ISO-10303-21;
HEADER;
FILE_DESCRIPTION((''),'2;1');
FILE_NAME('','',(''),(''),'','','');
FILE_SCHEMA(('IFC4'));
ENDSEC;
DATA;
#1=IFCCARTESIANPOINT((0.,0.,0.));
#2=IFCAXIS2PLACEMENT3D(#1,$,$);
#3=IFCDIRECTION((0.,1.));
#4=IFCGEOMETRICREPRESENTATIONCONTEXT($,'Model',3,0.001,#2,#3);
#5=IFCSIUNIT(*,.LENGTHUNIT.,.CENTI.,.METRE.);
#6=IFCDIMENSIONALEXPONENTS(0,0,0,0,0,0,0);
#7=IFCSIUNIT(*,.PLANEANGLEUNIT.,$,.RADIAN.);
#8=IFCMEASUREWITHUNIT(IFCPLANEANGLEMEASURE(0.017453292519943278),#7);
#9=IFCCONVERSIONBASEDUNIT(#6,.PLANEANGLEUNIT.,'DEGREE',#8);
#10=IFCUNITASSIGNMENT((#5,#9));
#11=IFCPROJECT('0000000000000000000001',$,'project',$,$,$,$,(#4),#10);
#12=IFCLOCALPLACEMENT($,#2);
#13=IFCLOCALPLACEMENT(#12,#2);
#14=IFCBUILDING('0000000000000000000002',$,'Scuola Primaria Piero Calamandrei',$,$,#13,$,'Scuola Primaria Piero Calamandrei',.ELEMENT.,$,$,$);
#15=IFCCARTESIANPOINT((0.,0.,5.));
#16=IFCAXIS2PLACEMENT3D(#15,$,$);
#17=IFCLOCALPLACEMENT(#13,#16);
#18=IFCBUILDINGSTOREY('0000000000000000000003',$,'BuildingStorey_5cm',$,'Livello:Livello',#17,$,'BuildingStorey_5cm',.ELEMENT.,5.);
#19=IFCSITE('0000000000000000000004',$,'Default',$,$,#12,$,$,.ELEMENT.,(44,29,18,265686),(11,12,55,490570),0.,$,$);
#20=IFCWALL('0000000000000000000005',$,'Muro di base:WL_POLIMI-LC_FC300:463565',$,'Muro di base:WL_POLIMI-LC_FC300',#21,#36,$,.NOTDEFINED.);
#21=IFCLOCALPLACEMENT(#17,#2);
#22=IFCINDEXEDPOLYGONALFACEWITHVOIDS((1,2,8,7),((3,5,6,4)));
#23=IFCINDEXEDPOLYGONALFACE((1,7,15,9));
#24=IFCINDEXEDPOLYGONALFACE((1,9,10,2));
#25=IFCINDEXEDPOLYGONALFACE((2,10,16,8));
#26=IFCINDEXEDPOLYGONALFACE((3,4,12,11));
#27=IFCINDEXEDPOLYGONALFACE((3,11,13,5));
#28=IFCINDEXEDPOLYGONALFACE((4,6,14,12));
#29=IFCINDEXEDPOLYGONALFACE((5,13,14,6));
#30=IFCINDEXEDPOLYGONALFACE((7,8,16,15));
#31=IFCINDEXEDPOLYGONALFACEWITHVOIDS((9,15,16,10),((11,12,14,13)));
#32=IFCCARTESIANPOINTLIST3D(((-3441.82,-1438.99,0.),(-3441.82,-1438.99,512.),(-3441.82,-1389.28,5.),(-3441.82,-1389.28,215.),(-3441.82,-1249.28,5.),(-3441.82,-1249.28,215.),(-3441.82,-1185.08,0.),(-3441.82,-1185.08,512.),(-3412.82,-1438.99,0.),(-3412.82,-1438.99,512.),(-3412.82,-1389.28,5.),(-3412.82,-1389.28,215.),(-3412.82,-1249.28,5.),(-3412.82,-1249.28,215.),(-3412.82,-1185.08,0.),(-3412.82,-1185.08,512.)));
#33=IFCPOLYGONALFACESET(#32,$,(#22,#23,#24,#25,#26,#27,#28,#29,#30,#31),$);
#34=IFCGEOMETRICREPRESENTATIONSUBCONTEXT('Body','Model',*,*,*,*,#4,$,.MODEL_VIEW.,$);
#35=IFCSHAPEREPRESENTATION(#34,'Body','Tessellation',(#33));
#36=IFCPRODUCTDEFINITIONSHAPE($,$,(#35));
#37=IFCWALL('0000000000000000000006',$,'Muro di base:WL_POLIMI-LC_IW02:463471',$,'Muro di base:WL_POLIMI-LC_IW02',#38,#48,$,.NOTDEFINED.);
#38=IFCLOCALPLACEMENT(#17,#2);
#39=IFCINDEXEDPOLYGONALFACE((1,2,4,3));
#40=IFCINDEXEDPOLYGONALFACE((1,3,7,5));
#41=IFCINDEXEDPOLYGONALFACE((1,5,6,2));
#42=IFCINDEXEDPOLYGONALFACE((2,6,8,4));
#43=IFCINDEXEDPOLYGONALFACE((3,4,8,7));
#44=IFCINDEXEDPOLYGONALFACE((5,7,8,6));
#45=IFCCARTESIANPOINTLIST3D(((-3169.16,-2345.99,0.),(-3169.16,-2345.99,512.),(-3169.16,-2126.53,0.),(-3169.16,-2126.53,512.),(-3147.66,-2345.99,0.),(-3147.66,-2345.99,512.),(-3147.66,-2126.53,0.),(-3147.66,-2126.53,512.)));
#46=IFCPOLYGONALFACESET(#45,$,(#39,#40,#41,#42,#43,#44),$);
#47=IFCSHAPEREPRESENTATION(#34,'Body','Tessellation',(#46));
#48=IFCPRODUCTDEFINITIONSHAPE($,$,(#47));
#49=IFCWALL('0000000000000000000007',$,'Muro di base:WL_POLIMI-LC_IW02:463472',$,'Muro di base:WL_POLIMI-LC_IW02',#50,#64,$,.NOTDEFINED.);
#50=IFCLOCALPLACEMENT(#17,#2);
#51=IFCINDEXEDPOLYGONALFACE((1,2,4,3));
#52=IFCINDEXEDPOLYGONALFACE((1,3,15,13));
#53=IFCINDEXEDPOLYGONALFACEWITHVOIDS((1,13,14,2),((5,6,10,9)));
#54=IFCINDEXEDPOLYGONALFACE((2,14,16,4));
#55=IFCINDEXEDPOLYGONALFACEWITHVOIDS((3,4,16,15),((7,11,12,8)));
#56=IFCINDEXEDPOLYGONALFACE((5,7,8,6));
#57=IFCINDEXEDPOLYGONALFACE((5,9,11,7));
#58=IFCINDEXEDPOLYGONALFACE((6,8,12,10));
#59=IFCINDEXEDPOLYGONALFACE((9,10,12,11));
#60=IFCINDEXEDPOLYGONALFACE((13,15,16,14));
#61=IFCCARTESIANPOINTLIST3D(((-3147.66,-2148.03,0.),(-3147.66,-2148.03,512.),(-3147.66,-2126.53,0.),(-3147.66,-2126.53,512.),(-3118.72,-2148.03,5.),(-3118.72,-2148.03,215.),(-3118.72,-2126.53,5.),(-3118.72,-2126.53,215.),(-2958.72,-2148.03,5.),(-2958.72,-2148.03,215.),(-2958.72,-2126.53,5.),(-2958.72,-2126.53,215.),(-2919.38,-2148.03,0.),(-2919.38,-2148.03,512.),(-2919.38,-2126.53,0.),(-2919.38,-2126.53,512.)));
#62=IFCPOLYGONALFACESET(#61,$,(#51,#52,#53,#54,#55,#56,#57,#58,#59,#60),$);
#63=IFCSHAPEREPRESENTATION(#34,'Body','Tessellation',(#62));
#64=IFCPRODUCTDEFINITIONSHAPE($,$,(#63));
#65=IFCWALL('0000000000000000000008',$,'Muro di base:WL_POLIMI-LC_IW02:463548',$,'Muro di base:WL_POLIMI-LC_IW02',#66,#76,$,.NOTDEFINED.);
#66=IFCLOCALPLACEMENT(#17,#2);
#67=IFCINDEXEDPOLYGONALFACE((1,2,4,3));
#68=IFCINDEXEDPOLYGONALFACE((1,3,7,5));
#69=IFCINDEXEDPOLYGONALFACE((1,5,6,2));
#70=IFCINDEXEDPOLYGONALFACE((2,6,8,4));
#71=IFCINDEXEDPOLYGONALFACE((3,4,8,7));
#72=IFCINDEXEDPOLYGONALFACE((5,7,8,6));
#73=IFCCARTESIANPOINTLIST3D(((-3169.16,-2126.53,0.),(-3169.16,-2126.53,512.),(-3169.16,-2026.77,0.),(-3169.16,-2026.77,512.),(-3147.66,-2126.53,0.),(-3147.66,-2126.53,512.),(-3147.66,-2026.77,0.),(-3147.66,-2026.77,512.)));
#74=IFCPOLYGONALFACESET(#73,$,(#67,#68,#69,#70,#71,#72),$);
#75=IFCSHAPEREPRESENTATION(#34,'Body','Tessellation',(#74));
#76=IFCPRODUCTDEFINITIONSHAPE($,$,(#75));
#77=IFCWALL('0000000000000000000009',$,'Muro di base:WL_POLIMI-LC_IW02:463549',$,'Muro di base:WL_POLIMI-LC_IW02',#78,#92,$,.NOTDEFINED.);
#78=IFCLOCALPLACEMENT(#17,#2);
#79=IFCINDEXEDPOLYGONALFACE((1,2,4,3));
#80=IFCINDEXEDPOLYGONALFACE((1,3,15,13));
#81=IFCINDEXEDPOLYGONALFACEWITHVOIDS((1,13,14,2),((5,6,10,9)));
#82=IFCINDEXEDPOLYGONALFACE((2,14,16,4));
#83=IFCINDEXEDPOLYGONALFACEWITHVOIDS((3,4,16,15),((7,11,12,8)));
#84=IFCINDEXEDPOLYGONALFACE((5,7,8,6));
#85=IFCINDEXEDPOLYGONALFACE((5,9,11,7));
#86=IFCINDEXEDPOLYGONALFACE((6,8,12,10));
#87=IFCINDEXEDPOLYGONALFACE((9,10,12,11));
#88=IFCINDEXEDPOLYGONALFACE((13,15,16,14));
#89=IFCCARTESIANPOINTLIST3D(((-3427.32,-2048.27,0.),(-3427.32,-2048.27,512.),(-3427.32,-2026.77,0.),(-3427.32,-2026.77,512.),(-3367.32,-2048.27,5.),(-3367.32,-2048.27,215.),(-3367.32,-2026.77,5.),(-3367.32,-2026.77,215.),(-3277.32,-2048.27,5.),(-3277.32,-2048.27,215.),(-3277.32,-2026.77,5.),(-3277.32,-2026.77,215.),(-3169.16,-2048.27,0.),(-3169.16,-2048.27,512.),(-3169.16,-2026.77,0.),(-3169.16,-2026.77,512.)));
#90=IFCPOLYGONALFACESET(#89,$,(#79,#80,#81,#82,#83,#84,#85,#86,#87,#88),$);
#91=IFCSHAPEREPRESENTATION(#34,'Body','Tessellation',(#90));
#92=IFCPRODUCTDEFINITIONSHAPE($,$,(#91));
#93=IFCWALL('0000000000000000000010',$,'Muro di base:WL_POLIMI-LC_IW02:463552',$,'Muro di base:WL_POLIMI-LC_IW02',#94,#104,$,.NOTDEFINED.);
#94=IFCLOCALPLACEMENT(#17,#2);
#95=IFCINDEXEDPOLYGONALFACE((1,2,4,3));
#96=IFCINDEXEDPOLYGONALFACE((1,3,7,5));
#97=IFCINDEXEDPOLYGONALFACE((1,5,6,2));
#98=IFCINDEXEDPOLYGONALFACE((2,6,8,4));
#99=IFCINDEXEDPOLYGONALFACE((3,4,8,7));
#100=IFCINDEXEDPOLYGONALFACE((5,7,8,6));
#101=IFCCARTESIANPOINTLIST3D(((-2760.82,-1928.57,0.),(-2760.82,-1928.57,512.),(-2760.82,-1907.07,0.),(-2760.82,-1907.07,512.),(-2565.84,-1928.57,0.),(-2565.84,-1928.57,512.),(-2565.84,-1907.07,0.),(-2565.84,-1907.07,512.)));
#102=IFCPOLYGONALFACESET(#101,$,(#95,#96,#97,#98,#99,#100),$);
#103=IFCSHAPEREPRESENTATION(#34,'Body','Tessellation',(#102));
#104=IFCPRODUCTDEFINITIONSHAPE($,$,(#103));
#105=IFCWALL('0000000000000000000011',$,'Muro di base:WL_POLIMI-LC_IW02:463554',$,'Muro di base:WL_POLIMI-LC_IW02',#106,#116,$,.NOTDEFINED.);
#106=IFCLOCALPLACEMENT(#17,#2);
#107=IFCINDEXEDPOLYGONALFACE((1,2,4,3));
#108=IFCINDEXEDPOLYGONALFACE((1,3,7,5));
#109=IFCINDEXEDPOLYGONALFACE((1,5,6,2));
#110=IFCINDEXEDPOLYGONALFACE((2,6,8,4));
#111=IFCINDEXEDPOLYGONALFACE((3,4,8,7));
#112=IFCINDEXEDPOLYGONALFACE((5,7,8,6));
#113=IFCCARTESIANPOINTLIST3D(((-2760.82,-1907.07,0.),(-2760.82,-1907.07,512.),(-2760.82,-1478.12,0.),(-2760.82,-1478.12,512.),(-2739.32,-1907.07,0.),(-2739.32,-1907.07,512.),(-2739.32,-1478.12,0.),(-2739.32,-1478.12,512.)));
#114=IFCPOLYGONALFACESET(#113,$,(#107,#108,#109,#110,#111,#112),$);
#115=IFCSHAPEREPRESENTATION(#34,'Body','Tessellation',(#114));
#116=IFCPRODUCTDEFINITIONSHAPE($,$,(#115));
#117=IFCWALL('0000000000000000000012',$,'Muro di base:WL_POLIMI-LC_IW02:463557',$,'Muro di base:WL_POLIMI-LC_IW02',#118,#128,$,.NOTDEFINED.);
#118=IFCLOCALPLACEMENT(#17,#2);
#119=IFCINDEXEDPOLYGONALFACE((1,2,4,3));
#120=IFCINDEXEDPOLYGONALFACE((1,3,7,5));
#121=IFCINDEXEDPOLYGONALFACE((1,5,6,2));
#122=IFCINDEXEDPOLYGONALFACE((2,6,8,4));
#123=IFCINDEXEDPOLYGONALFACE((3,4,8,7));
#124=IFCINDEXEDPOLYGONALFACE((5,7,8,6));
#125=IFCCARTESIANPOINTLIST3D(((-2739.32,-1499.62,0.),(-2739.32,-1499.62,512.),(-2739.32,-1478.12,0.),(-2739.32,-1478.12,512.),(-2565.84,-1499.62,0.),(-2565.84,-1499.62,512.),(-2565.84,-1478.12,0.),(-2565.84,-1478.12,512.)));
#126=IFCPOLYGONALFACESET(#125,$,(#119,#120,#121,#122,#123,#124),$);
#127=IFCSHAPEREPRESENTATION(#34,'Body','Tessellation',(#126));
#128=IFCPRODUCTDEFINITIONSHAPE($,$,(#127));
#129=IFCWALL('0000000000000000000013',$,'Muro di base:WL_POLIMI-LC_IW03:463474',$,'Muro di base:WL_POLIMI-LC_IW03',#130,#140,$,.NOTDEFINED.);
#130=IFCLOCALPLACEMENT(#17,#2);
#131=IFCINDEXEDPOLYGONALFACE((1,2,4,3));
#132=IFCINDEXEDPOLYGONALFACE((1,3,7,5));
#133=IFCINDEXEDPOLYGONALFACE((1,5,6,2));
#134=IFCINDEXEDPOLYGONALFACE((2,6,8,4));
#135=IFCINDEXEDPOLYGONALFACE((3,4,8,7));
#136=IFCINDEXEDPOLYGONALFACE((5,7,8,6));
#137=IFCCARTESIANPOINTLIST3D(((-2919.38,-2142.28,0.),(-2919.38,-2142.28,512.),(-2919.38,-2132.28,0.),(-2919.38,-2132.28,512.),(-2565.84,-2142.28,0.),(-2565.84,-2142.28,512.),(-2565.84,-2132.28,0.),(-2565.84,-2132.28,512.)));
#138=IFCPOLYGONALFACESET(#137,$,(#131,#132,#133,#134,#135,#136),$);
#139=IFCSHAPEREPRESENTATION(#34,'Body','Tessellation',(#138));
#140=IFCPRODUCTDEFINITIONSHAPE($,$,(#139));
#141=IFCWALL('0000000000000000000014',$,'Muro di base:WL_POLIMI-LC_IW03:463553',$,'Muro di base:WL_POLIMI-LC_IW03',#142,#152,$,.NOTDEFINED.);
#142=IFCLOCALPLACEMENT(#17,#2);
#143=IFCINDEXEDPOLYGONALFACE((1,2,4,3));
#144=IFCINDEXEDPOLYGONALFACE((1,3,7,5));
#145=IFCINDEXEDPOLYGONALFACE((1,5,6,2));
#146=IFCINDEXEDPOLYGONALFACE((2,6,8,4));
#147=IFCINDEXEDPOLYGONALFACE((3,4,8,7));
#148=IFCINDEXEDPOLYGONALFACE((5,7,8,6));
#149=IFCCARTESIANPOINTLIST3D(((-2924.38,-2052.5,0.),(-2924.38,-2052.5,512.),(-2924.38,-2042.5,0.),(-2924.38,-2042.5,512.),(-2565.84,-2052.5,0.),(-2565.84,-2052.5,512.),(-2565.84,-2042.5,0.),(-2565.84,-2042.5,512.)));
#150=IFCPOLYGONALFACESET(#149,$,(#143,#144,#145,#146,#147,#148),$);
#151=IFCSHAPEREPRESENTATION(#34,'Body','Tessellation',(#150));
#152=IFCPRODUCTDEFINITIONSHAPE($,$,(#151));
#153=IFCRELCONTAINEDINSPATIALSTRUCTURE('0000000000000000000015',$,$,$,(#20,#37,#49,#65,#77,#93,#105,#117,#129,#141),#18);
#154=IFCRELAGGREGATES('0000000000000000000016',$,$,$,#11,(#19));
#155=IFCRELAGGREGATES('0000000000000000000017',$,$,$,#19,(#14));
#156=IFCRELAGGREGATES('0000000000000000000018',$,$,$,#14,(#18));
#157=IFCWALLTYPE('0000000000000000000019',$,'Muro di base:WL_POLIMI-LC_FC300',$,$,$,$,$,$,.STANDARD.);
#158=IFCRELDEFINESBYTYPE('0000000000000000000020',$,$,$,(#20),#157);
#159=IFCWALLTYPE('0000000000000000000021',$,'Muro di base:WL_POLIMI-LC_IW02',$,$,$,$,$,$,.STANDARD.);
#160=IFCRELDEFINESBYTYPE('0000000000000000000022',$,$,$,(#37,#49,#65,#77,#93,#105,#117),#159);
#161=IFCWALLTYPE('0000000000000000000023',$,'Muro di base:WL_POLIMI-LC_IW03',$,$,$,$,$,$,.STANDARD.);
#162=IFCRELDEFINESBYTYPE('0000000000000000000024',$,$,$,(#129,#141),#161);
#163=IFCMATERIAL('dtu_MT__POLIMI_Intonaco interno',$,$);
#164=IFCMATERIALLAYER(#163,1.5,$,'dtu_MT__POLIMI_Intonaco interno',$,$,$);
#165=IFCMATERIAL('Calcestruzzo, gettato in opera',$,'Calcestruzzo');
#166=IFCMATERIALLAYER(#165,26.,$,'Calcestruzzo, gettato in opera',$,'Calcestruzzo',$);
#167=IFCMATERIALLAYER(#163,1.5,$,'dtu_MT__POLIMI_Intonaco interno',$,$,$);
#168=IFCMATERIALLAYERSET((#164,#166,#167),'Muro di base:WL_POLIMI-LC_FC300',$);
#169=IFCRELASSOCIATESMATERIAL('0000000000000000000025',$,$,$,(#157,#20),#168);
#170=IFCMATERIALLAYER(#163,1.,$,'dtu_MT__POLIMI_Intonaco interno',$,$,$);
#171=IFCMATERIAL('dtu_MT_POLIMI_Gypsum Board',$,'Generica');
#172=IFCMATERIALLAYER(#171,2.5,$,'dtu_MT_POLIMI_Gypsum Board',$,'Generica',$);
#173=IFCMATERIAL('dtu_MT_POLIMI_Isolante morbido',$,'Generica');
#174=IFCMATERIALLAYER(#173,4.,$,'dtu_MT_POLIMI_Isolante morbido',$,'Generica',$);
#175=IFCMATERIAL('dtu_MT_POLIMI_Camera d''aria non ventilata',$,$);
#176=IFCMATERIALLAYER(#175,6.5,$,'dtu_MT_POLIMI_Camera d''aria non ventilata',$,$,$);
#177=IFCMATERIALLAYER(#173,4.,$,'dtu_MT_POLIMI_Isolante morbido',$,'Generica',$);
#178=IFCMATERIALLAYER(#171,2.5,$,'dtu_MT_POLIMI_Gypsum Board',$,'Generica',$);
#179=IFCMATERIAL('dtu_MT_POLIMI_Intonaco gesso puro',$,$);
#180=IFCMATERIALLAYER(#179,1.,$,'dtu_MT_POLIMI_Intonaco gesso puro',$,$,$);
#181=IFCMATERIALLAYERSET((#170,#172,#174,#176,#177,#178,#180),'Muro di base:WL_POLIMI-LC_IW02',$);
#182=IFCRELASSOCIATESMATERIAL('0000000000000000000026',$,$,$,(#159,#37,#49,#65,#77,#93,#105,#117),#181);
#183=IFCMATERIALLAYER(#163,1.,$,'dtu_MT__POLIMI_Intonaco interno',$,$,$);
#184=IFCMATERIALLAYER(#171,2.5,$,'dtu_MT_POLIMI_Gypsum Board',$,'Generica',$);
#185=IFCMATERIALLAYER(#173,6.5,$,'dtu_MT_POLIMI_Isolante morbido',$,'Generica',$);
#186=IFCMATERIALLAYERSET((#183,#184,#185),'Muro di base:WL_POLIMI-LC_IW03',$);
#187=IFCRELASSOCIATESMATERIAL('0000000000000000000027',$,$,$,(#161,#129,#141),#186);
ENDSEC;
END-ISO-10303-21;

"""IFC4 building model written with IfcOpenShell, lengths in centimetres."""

from ifc_helpers import new_model, entity, si_unit, converted_unit, direction, frame, frame_2d, origin, place, context, subcontext, project, spatial, rectangle, extrude, material, layer, layer_set, layer_usage, type_object, element, save


model = new_model("IFC4")

# Units and contexts
model_context = context("Model", 3, precision=0.001, world=origin(), true_north=direction((0.0, 1.0)))
body_context = subcontext(model_context, "Body", "Model", "MODEL_VIEW")
ifc_project = project(units=[si_unit("LENGTHUNIT", "METRE", prefix="CENTI"), converted_unit("PLANEANGLEUNIT", "DEGREE", entity("IfcPlaneAngleMeasure", 0.017453292519943278), si_unit("PLANEANGLEUNIT", "RADIAN"), dimensions=[0, 0, 0, 0, 0, 0, 0])], contexts=[model_context])

# Site, building, storey
site_placement = place(None, origin())
site = spatial("IfcSite", under=ifc_project, at=site_placement, Name="Default", CompositionType="ELEMENT", RefLatitude=(44, 29, 18, 265686), RefLongitude=(11, 12, 55, 490570), RefElevation=0.0)
building_placement = place(site_placement, origin())
building = spatial("IfcBuilding", under=site, at=building_placement, Name="Scuola Primaria Piero Calamandrei", LongName="Scuola Primaria Piero Calamandrei", CompositionType="ELEMENT")
storey_placement = place(building_placement, frame((0.0, 0.0, 5.0)))
storey = spatial("IfcBuildingStorey", under=building, at=storey_placement, Name="BuildingStorey_5cm", ObjectType="Livello:Livello", LongName="BuildingStorey_5cm", CompositionType="ELEMENT", Elevation=5.0)

# Shared definitions
ifc_material_1 = material(Name="dtu_MT_POLIMI_Intonaco gesso puro")

# Wall, opening
ifc_material_2 = material(Name="dtu_MT__POLIMI_Intonaco interno")
ifc_layer_1 = layer(ifc_material_2, 1.5, Name="dtu_MT__POLIMI_Intonaco interno")
ifc_material_3 = material(Name="Calcestruzzo, gettato in opera", Category="Calcestruzzo")
ifc_layer_2 = layer(ifc_material_3, 26.0, Name="Calcestruzzo, gettato in opera", Category="Calcestruzzo")
ifc_layer_3 = layer(ifc_material_2, 1.5, Name="dtu_MT__POLIMI_Intonaco interno")
ifc_layer_set_1 = layer_set([ifc_layer_1, ifc_layer_2, ifc_layer_3], Name="Muro di base:WL_POLIMI-LC_FC300")
ifc_layer_usage_1 = layer_usage(ifc_layer_set_1, "AXIS2", "NEGATIVE", 14.5)
wall_type_1 = type_object("IfcWallType", Name="Muro di base:WL_POLIMI-LC_FC300", PredefinedType="STANDARD", material=ifc_layer_set_1)
wall_1_placement = place(storey_placement, frame((-3427.32, -1438.99, 0.0), z_axis=(0.0, 0.0, 1.0), x_axis=(0.0, 1.0, 0.0)))
wall_1 = element("IfcWall", 1, at=wall_1_placement, inside=storey, type_object=wall_type_1, material=ifc_layer_usage_1, Name="Muro di base:WL_POLIMI-LC_FC300:463565", ObjectType="Muro di base:WL_POLIMI-LC_FC300", PredefinedType="NOTDEFINED", context=body_context, shape_type="SweptSolid", body=[
    extrude(rectangle(XDim=253.91, YDim=29.0, at=frame_2d((126.96, 0.0), x_axis=(-1.0, 0.0))), origin(), (0.0, 0.0, 1.0), 512.0),
])
opening_1_placement = place(wall_1_placement, frame((49.71, -14.5, 5.0)))
element("IfcOpeningElement", 2, at=opening_1_placement, cuts=wall_1, PredefinedType="OPENING", context=body_context, shape_type="SweptSolid", body=[
    extrude(rectangle(XDim=210.0, YDim=140.0, at=frame_2d((105.0, 70.0), x_axis=(1.0, 0.0))), frame((0.0, 0.0, 0.0), z_axis=(0.0, 1.0, 0.0), x_axis=(0.0, 0.0, 1.0)), (0.0, 0.0, 1.0), 29.0),
])

# Wall
ifc_layer_4 = layer(ifc_material_2, 1.0, Name="dtu_MT__POLIMI_Intonaco interno")
ifc_material_4 = material(Name="dtu_MT_POLIMI_Gypsum Board", Category="Generica")
ifc_layer_5 = layer(ifc_material_4, 2.5, Name="dtu_MT_POLIMI_Gypsum Board", Category="Generica")
ifc_material_5 = material(Name="dtu_MT_POLIMI_Isolante morbido", Category="Generica")
ifc_layer_6 = layer(ifc_material_5, 4.0, Name="dtu_MT_POLIMI_Isolante morbido", Category="Generica")
ifc_material_6 = material(Name="dtu_MT_POLIMI_Camera d'aria non ventilata")
ifc_layer_7 = layer(ifc_material_6, 6.5, Name="dtu_MT_POLIMI_Camera d'aria non ventilata")
ifc_layer_8 = layer(ifc_material_5, 4.0, Name="dtu_MT_POLIMI_Isolante morbido", Category="Generica")
ifc_layer_9 = layer(ifc_material_4, 2.5, Name="dtu_MT_POLIMI_Gypsum Board", Category="Generica")
ifc_layer_10 = layer(ifc_material_1, 1.0, Name="dtu_MT_POLIMI_Intonaco gesso puro")
ifc_layer_set_2 = layer_set([ifc_layer_4, ifc_layer_5, ifc_layer_6, ifc_layer_7, ifc_layer_8, ifc_layer_9, ifc_layer_10], Name="Muro di base:WL_POLIMI-LC_IW02")
ifc_layer_usage_2 = layer_usage(ifc_layer_set_2, "AXIS2", "NEGATIVE", 10.75)
wall_type_2 = type_object("IfcWallType", Name="Muro di base:WL_POLIMI-LC_IW02", PredefinedType="STANDARD", material=ifc_layer_set_2)
wall_2_placement = place(storey_placement, frame((-3158.41, -2345.99, 0.0), z_axis=(0.0, 0.0, 1.0), x_axis=(0.0, 1.0, 0.0)))
element("IfcWall", 3, at=wall_2_placement, inside=storey, type_object=wall_type_2, material=ifc_layer_usage_2, Name="Muro di base:WL_POLIMI-LC_IW02:463471", ObjectType="Muro di base:WL_POLIMI-LC_IW02", PredefinedType="NOTDEFINED", context=body_context, shape_type="SweptSolid", body=[
    extrude(rectangle(XDim=219.46, YDim=21.5, at=frame_2d((109.73, 0.0), x_axis=(-1.0, 0.0))), origin(), (0.0, 0.0, 1.0), 512.0),
])

# Wall, opening
ifc_layer_usage_3 = layer_usage(ifc_layer_set_2, "AXIS2", "NEGATIVE", 10.75)
wall_3_placement = place(storey_placement, frame((-3147.66, -2137.28, 0.0)))
wall_3 = element("IfcWall", 4, at=wall_3_placement, inside=storey, type_object=wall_type_2, material=ifc_layer_usage_3, Name="Muro di base:WL_POLIMI-LC_IW02:463472", ObjectType="Muro di base:WL_POLIMI-LC_IW02", PredefinedType="NOTDEFINED", context=body_context, shape_type="SweptSolid", body=[
    extrude(rectangle(XDim=228.28, YDim=21.5, at=frame_2d((114.14, 0.0), x_axis=(-1.0, 0.0))), origin(), (0.0, 0.0, 1.0), 512.0),
])
opening_2_placement = place(wall_3_placement, frame((28.94, -10.75, 5.0)))
element("IfcOpeningElement", 5, at=opening_2_placement, cuts=wall_3, PredefinedType="OPENING", context=body_context, shape_type="SweptSolid", body=[
    extrude(rectangle(XDim=210.0, YDim=160.0, at=frame_2d((105.0, 80.0), x_axis=(-1.0, 0.0))), frame((0.0, 0.0, 0.0), z_axis=(0.0, 1.0, 0.0), x_axis=(0.0, 0.0, 1.0)), (0.0, 0.0, 1.0), 21.5),
])

# Wall
ifc_layer_usage_4 = layer_usage(ifc_layer_set_2, "AXIS2", "NEGATIVE", 10.75)
wall_4_placement = place(storey_placement, frame((-3158.41, -2026.77, 0.0), z_axis=(0.0, 0.0, 1.0), x_axis=(0.0, -1.0, 0.0)))
element("IfcWall", 6, at=wall_4_placement, inside=storey, type_object=wall_type_2, material=ifc_layer_usage_4, Name="Muro di base:WL_POLIMI-LC_IW02:463548", ObjectType="Muro di base:WL_POLIMI-LC_IW02", PredefinedType="NOTDEFINED", context=body_context, shape_type="SweptSolid", body=[
    extrude(rectangle(XDim=99.76, YDim=21.5, at=frame_2d((49.88, 0.0), x_axis=(-1.0, 0.0))), origin(), (0.0, 0.0, 1.0), 512.0),
])

# Wall, opening
ifc_layer_usage_5 = layer_usage(ifc_layer_set_2, "AXIS2", "NEGATIVE", 10.75)
wall_5_placement = place(storey_placement, frame((-3427.32, -2037.52, 0.0)))
wall_5 = element("IfcWall", 7, at=wall_5_placement, inside=storey, type_object=wall_type_2, material=ifc_layer_usage_5, Name="Muro di base:WL_POLIMI-LC_IW02:463549", ObjectType="Muro di base:WL_POLIMI-LC_IW02", PredefinedType="NOTDEFINED", context=body_context, shape_type="SweptSolid", body=[
    extrude(rectangle(XDim=258.16, YDim=21.5, at=frame_2d((129.08, 0.0), x_axis=(-1.0, 0.0))), origin(), (0.0, 0.0, 1.0), 512.0),
])
opening_3_placement = place(wall_5_placement, frame((60.0, -10.75, 5.0)))
element("IfcOpeningElement", 8, at=opening_3_placement, cuts=wall_5, PredefinedType="OPENING", context=body_context, shape_type="SweptSolid", body=[
    extrude(rectangle(XDim=210.0, YDim=90.0, at=frame_2d((105.0, 45.0), x_axis=(1.0, 0.0))), frame((0.0, 0.0, 0.0), z_axis=(0.0, 1.0, 0.0), x_axis=(0.0, 0.0, 1.0)), (0.0, 0.0, 1.0), 21.5),
])

# Walls
ifc_layer_usage_6 = layer_usage(ifc_layer_set_2, "AXIS2", "NEGATIVE", 10.75)
wall_6_placement = place(storey_placement, frame((-2760.82, -1917.82, 0.0)))
element("IfcWall", 9, at=wall_6_placement, inside=storey, type_object=wall_type_2, material=ifc_layer_usage_6, Name="Muro di base:WL_POLIMI-LC_IW02:463552", ObjectType="Muro di base:WL_POLIMI-LC_IW02", PredefinedType="NOTDEFINED", context=body_context, shape_type="SweptSolid", body=[
    extrude(rectangle(XDim=194.98, YDim=21.5, at=frame_2d((97.49, 0.0), x_axis=(-1.0, 0.0))), origin(), (0.0, 0.0, 1.0), 512.0),
])
ifc_layer_usage_7 = layer_usage(ifc_layer_set_2, "AXIS2", "NEGATIVE", 10.75)
wall_7_placement = place(storey_placement, frame((-2750.07, -1478.12, 0.0), z_axis=(0.0, 0.0, 1.0), x_axis=(0.0, -1.0, 0.0)))
element("IfcWall", 10, at=wall_7_placement, inside=storey, type_object=wall_type_2, material=ifc_layer_usage_7, Name="Muro di base:WL_POLIMI-LC_IW02:463554", ObjectType="Muro di base:WL_POLIMI-LC_IW02", PredefinedType="NOTDEFINED", context=body_context, shape_type="SweptSolid", body=[
    extrude(rectangle(XDim=428.95, YDim=21.5, at=frame_2d((214.47, 0.0), x_axis=(-1.0, 0.0))), origin(), (0.0, 0.0, 1.0), 512.0),
])
ifc_layer_usage_8 = layer_usage(ifc_layer_set_2, "AXIS2", "NEGATIVE", 10.75)
wall_8_placement = place(storey_placement, frame((-2565.84, -1488.87, 0.0), z_axis=(0.0, 0.0, 1.0), x_axis=(-1.0, 0.0, 0.0)))
element("IfcWall", 11, at=wall_8_placement, inside=storey, type_object=wall_type_2, material=ifc_layer_usage_8, Name="Muro di base:WL_POLIMI-LC_IW02:463557", ObjectType="Muro di base:WL_POLIMI-LC_IW02", PredefinedType="NOTDEFINED", context=body_context, shape_type="SweptSolid", body=[
    extrude(rectangle(XDim=173.48, YDim=21.5, at=frame_2d((86.74, 0.0), x_axis=(-1.0, 0.0))), origin(), (0.0, 0.0, 1.0), 512.0),
])
ifc_layer_11 = layer(ifc_material_2, 1.0, Name="dtu_MT__POLIMI_Intonaco interno")
ifc_layer_12 = layer(ifc_material_4, 2.5, Name="dtu_MT_POLIMI_Gypsum Board", Category="Generica")
ifc_layer_13 = layer(ifc_material_5, 6.5, Name="dtu_MT_POLIMI_Isolante morbido", Category="Generica")
ifc_layer_set_3 = layer_set([ifc_layer_11, ifc_layer_12, ifc_layer_13], Name="Muro di base:WL_POLIMI-LC_IW03")
ifc_layer_usage_9 = layer_usage(ifc_layer_set_3, "AXIS2", "NEGATIVE", 5.0)
wall_type_3 = type_object("IfcWallType", Name="Muro di base:WL_POLIMI-LC_IW03", PredefinedType="STANDARD", material=ifc_layer_set_3)
wall_9_placement = place(storey_placement, frame((-2919.38, -2137.28, 0.0)))
element("IfcWall", 12, at=wall_9_placement, inside=storey, type_object=wall_type_3, material=ifc_layer_usage_9, Name="Muro di base:WL_POLIMI-LC_IW03:463474", ObjectType="Muro di base:WL_POLIMI-LC_IW03", PredefinedType="NOTDEFINED", context=body_context, shape_type="SweptSolid", body=[
    extrude(rectangle(XDim=353.55, YDim=10.0, at=frame_2d((176.77, 0.0), x_axis=(-1.0, 0.0))), origin(), (0.0, 0.0, 1.0), 512.0),
])
ifc_layer_usage_10 = layer_usage(ifc_layer_set_3, "AXIS2", "NEGATIVE", 5.0)
wall_10_placement = place(storey_placement, frame((-2565.84, -2047.5, 0.0), z_axis=(0.0, 0.0, 1.0), x_axis=(-1.0, 0.0, 0.0)))
element("IfcWall", 13, at=wall_10_placement, inside=storey, type_object=wall_type_3, material=ifc_layer_usage_10, Name="Muro di base:WL_POLIMI-LC_IW03:463553", ObjectType="Muro di base:WL_POLIMI-LC_IW03", PredefinedType="NOTDEFINED", context=body_context, shape_type="SweptSolid", body=[
    extrude(rectangle(XDim=358.55, YDim=10.0, at=frame_2d((179.27, 0.0), x_axis=(-1.0, 0.0))), origin(), (0.0, 0.0, 1.0), 512.0),
])

save(model, "model.ifc")
